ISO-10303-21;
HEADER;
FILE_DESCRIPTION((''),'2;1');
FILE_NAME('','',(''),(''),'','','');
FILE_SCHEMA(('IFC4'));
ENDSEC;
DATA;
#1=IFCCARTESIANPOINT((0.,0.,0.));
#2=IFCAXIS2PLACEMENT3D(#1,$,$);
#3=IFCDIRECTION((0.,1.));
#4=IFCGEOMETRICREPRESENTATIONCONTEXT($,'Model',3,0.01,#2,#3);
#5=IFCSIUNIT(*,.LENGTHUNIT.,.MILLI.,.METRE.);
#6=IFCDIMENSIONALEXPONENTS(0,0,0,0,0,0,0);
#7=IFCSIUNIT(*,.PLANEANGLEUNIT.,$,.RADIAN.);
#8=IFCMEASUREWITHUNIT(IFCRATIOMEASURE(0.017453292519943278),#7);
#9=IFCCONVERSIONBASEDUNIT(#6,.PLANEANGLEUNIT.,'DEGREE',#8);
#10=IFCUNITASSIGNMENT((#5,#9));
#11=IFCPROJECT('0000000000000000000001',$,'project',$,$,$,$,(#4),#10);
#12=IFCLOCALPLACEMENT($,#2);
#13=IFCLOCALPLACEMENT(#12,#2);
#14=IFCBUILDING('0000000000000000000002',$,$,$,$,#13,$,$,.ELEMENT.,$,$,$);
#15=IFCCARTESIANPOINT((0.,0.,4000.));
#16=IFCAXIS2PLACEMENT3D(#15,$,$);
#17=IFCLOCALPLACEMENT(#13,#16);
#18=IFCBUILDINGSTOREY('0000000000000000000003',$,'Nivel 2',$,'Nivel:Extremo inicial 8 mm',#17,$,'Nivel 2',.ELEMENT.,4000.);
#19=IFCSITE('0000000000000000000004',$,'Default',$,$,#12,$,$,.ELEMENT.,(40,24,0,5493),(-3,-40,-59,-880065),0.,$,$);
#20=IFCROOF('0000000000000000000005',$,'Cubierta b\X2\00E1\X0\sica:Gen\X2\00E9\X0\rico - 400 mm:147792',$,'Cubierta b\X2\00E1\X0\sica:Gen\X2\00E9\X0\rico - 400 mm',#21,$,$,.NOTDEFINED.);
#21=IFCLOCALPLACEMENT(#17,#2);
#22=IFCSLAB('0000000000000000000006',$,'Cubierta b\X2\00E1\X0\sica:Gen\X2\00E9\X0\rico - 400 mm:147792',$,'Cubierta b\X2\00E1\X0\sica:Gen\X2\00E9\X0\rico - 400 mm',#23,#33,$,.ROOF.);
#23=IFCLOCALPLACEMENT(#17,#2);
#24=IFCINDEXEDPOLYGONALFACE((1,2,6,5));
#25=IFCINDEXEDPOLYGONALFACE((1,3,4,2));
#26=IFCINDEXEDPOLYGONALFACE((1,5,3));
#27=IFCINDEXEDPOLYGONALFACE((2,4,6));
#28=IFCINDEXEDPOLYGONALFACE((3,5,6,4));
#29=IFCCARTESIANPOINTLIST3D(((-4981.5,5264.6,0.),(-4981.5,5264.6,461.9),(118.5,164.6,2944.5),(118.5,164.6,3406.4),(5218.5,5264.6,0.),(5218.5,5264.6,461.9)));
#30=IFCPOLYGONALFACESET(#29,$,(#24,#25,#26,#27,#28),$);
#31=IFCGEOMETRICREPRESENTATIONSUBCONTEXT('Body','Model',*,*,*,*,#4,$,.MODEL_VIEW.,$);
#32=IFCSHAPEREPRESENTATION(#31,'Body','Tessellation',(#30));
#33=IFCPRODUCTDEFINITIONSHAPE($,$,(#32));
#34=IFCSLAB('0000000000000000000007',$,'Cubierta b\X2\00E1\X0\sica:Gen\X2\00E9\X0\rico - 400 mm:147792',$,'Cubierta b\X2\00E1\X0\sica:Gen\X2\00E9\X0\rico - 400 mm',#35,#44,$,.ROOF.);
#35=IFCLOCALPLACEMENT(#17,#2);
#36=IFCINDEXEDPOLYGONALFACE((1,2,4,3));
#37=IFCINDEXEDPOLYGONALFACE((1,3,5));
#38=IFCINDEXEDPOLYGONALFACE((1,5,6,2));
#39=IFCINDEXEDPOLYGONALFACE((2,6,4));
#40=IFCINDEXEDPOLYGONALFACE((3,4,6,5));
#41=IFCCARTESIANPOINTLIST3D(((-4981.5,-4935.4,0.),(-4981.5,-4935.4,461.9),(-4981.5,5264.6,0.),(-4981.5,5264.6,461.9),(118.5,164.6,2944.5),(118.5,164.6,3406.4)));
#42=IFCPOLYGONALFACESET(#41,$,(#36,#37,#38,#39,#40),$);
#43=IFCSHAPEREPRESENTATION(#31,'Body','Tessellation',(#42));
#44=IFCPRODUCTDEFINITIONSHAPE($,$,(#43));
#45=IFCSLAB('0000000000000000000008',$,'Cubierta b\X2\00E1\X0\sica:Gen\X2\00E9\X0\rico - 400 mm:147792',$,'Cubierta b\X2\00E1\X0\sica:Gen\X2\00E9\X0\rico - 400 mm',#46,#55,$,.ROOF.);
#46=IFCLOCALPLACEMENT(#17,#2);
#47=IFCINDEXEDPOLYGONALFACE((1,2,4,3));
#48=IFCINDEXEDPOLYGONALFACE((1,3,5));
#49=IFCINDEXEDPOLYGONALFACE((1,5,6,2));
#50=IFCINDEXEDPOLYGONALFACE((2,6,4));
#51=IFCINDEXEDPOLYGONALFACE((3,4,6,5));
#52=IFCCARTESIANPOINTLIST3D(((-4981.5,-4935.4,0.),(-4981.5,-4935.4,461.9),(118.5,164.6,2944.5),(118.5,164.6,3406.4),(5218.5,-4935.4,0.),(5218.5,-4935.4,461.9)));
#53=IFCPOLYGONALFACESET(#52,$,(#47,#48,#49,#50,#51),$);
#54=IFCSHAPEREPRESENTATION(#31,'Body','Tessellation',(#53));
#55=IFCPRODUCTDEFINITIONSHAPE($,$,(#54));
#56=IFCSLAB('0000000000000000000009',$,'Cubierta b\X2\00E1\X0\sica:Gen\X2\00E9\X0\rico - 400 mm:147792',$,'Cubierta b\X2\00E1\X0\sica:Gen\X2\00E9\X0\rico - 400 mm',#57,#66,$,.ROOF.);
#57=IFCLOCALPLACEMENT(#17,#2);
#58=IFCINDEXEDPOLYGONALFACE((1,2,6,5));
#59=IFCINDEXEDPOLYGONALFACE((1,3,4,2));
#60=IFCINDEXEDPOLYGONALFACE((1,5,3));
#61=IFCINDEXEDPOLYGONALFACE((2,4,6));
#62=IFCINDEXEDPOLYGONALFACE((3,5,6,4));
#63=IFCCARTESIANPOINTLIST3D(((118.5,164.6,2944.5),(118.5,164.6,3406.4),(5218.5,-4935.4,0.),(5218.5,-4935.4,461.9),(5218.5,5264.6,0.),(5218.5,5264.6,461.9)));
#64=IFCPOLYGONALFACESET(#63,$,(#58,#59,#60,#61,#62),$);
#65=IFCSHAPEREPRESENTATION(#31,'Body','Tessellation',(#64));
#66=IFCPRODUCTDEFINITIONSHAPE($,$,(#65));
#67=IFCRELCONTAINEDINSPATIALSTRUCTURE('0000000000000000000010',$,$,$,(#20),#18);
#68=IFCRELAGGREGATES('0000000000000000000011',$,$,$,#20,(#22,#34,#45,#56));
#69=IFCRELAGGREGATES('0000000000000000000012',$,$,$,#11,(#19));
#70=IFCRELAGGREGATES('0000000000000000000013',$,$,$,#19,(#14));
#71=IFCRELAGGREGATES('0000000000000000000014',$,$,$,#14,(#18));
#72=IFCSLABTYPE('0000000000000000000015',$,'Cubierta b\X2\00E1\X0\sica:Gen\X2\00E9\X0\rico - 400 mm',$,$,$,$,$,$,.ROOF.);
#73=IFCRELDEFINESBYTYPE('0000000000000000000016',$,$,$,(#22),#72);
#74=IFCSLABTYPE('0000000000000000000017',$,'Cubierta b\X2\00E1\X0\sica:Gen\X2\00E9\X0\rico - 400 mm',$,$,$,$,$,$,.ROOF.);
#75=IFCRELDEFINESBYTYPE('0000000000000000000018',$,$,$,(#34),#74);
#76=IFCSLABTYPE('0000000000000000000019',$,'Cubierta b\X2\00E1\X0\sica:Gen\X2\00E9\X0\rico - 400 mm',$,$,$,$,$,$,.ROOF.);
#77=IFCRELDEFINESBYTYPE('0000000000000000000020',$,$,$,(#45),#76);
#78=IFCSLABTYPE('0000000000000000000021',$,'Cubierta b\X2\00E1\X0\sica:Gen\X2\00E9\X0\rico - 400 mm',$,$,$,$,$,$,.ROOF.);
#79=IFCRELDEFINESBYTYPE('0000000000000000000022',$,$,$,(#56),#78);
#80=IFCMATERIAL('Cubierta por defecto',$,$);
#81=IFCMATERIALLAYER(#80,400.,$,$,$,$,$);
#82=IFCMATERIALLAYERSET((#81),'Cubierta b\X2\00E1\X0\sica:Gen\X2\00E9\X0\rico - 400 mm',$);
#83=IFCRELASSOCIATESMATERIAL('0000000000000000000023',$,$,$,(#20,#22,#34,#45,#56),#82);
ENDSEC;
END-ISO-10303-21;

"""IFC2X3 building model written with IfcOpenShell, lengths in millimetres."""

from ifc_helpers import new_model, entity, si_unit, converted_unit, direction, frame, origin, place, context, subcontext, project, spatial, polyline, outline, extrude, material, layer, layer_set, type_object, element, aggregate, save


model = new_model("IFC2X3")

# Units and contexts
model_context = context("Model", 3, precision=0.01, world=origin(), true_north=direction((0.0, 1.0)))
body_context = subcontext(model_context, "Body", "Model", "MODEL_VIEW")
ifc_project = project(units=[si_unit("LENGTHUNIT", "METRE", prefix="MILLI"), converted_unit("PLANEANGLEUNIT", "DEGREE", entity("IfcRatioMeasure", 0.017453292519943278), si_unit("PLANEANGLEUNIT", "RADIAN"), dimensions=[0, 0, 0, 0, 0, 0, 0])], contexts=[model_context])

# Site, building, storey
site_placement = place(None, origin())
site = spatial("IfcSite", under=ifc_project, at=site_placement, Name="Default", CompositionType="ELEMENT", RefLatitude=(40, 24, 0, 5493), RefLongitude=(-3, -40, -59, -880065), RefElevation=0.0)
building_placement = place(site_placement, origin())
building = spatial("IfcBuilding", under=site, at=building_placement, CompositionType="ELEMENT")
storey_placement = place(building_placement, frame((0.0, 0.0, 4000.0)))
storey = spatial("IfcBuildingStorey", under=building, at=storey_placement, Name="Nivel 2", ObjectType="Nivel:Extremo inicial 8 mm", LongName="Nivel 2", CompositionType="ELEMENT", Elevation=4000.0)

# Roof, slabs
ifc_material = material(Name="Cubierta por defecto")
ifc_layer = layer(ifc_material, 400.0)
ifc_layer_set = layer_set([ifc_layer], Name="Cubierta básica:Genérico - 400 mm")
roof_placement = place(storey_placement, frame((-4981.5, -4935.4, 0.0)))
roof = element("IfcRoof", 1, at=roof_placement, inside=storey, material=ifc_layer_set, Name="Cubierta básica:Genérico - 400 mm:147792", ObjectType="Cubierta básica:Genérico - 400 mm", ShapeType="NOTDEFINED")
slab_type_1 = type_object("IfcSlabType", Name="Cubierta básica:Genérico - 400 mm", PredefinedType="ROOF")
slab_1_placement = place(roof_placement, origin())
slab_1 = element("IfcSlab", 2, at=slab_1_placement, type_object=slab_type_1, material=ifc_layer_set, Name="Cubierta básica:Genérico - 400 mm:147792", ObjectType="Cubierta básica:Genérico - 400 mm", PredefinedType="ROOF", context=body_context, shape_type="SweptSolid", body=[
    extrude(outline(polyline([(5100.0, 2944.5), (-5100.0, 2944.5), (0.0, -2944.5), (5100.0, 2944.5)])), frame((5100.0, 7650.0, 1472.2), z_axis=(0.0, 0.5, 0.866025), x_axis=(1.0, 0.0, 0.0)), (0.0, -0.5, 0.866025), 461.9),
])
slab_type_2 = type_object("IfcSlabType", Name="Cubierta básica:Genérico - 400 mm", PredefinedType="ROOF")
slab_2_placement = place(roof_placement, origin())
slab_2 = element("IfcSlab", 3, at=slab_2_placement, type_object=slab_type_2, material=ifc_layer_set, Name="Cubierta básica:Genérico - 400 mm:147792", ObjectType="Cubierta básica:Genérico - 400 mm", PredefinedType="ROOF", context=body_context, shape_type="SweptSolid", body=[
    extrude(outline(polyline([(-2944.5, 5100.0), (-2944.5, -5100.0), (2944.5, 0.0), (-2944.5, 5100.0)])), frame((2550.0, 5100.0, 1472.2), z_axis=(-0.5, 0.0, 0.866025), x_axis=(0.866025, 0.0, 0.5)), (0.5, 0.0, 0.866025), 461.9),
])
slab_type_3 = type_object("IfcSlabType", Name="Cubierta básica:Genérico - 400 mm", PredefinedType="ROOF")
slab_3_placement = place(roof_placement, origin())
slab_3 = element("IfcSlab", 4, at=slab_3_placement, type_object=slab_type_3, material=ifc_layer_set, Name="Cubierta básica:Genérico - 400 mm:147792", ObjectType="Cubierta básica:Genérico - 400 mm", PredefinedType="ROOF", context=body_context, shape_type="SweptSolid", body=[
    extrude(outline(polyline([(-5100.0, -2944.5), (5100.0, -2944.5), (0.0, 2944.5), (-5100.0, -2944.5)])), frame((5100.0, 2550.0, 1472.2), z_axis=(0.0, -0.5, 0.866025), x_axis=(1.0, 0.0, 0.0)), (0.0, 0.5, 0.866025), 461.9),
])
slab_type_4 = type_object("IfcSlabType", Name="Cubierta básica:Genérico - 400 mm", PredefinedType="ROOF")
slab_4_placement = place(roof_placement, origin())
slab_4 = element("IfcSlab", 5, at=slab_4_placement, type_object=slab_type_4, material=ifc_layer_set, Name="Cubierta básica:Genérico - 400 mm:147792", ObjectType="Cubierta básica:Genérico - 400 mm", PredefinedType="ROOF", context=body_context, shape_type="SweptSolid", body=[
    extrude(outline(polyline([(-2944.5, 0.0), (2944.5, -5100.0), (2944.5, 5100.0), (-2944.5, 0.0)])), frame((7650.0, 5100.0, 1472.2), z_axis=(0.5, 0.0, 0.866025), x_axis=(0.866025, 0.0, -0.5)), (-0.5, 0.0, 0.866025), 461.9),
])
aggregate(roof, [slab_1, slab_2, slab_3, slab_4])

save(model, "model.ifc")
